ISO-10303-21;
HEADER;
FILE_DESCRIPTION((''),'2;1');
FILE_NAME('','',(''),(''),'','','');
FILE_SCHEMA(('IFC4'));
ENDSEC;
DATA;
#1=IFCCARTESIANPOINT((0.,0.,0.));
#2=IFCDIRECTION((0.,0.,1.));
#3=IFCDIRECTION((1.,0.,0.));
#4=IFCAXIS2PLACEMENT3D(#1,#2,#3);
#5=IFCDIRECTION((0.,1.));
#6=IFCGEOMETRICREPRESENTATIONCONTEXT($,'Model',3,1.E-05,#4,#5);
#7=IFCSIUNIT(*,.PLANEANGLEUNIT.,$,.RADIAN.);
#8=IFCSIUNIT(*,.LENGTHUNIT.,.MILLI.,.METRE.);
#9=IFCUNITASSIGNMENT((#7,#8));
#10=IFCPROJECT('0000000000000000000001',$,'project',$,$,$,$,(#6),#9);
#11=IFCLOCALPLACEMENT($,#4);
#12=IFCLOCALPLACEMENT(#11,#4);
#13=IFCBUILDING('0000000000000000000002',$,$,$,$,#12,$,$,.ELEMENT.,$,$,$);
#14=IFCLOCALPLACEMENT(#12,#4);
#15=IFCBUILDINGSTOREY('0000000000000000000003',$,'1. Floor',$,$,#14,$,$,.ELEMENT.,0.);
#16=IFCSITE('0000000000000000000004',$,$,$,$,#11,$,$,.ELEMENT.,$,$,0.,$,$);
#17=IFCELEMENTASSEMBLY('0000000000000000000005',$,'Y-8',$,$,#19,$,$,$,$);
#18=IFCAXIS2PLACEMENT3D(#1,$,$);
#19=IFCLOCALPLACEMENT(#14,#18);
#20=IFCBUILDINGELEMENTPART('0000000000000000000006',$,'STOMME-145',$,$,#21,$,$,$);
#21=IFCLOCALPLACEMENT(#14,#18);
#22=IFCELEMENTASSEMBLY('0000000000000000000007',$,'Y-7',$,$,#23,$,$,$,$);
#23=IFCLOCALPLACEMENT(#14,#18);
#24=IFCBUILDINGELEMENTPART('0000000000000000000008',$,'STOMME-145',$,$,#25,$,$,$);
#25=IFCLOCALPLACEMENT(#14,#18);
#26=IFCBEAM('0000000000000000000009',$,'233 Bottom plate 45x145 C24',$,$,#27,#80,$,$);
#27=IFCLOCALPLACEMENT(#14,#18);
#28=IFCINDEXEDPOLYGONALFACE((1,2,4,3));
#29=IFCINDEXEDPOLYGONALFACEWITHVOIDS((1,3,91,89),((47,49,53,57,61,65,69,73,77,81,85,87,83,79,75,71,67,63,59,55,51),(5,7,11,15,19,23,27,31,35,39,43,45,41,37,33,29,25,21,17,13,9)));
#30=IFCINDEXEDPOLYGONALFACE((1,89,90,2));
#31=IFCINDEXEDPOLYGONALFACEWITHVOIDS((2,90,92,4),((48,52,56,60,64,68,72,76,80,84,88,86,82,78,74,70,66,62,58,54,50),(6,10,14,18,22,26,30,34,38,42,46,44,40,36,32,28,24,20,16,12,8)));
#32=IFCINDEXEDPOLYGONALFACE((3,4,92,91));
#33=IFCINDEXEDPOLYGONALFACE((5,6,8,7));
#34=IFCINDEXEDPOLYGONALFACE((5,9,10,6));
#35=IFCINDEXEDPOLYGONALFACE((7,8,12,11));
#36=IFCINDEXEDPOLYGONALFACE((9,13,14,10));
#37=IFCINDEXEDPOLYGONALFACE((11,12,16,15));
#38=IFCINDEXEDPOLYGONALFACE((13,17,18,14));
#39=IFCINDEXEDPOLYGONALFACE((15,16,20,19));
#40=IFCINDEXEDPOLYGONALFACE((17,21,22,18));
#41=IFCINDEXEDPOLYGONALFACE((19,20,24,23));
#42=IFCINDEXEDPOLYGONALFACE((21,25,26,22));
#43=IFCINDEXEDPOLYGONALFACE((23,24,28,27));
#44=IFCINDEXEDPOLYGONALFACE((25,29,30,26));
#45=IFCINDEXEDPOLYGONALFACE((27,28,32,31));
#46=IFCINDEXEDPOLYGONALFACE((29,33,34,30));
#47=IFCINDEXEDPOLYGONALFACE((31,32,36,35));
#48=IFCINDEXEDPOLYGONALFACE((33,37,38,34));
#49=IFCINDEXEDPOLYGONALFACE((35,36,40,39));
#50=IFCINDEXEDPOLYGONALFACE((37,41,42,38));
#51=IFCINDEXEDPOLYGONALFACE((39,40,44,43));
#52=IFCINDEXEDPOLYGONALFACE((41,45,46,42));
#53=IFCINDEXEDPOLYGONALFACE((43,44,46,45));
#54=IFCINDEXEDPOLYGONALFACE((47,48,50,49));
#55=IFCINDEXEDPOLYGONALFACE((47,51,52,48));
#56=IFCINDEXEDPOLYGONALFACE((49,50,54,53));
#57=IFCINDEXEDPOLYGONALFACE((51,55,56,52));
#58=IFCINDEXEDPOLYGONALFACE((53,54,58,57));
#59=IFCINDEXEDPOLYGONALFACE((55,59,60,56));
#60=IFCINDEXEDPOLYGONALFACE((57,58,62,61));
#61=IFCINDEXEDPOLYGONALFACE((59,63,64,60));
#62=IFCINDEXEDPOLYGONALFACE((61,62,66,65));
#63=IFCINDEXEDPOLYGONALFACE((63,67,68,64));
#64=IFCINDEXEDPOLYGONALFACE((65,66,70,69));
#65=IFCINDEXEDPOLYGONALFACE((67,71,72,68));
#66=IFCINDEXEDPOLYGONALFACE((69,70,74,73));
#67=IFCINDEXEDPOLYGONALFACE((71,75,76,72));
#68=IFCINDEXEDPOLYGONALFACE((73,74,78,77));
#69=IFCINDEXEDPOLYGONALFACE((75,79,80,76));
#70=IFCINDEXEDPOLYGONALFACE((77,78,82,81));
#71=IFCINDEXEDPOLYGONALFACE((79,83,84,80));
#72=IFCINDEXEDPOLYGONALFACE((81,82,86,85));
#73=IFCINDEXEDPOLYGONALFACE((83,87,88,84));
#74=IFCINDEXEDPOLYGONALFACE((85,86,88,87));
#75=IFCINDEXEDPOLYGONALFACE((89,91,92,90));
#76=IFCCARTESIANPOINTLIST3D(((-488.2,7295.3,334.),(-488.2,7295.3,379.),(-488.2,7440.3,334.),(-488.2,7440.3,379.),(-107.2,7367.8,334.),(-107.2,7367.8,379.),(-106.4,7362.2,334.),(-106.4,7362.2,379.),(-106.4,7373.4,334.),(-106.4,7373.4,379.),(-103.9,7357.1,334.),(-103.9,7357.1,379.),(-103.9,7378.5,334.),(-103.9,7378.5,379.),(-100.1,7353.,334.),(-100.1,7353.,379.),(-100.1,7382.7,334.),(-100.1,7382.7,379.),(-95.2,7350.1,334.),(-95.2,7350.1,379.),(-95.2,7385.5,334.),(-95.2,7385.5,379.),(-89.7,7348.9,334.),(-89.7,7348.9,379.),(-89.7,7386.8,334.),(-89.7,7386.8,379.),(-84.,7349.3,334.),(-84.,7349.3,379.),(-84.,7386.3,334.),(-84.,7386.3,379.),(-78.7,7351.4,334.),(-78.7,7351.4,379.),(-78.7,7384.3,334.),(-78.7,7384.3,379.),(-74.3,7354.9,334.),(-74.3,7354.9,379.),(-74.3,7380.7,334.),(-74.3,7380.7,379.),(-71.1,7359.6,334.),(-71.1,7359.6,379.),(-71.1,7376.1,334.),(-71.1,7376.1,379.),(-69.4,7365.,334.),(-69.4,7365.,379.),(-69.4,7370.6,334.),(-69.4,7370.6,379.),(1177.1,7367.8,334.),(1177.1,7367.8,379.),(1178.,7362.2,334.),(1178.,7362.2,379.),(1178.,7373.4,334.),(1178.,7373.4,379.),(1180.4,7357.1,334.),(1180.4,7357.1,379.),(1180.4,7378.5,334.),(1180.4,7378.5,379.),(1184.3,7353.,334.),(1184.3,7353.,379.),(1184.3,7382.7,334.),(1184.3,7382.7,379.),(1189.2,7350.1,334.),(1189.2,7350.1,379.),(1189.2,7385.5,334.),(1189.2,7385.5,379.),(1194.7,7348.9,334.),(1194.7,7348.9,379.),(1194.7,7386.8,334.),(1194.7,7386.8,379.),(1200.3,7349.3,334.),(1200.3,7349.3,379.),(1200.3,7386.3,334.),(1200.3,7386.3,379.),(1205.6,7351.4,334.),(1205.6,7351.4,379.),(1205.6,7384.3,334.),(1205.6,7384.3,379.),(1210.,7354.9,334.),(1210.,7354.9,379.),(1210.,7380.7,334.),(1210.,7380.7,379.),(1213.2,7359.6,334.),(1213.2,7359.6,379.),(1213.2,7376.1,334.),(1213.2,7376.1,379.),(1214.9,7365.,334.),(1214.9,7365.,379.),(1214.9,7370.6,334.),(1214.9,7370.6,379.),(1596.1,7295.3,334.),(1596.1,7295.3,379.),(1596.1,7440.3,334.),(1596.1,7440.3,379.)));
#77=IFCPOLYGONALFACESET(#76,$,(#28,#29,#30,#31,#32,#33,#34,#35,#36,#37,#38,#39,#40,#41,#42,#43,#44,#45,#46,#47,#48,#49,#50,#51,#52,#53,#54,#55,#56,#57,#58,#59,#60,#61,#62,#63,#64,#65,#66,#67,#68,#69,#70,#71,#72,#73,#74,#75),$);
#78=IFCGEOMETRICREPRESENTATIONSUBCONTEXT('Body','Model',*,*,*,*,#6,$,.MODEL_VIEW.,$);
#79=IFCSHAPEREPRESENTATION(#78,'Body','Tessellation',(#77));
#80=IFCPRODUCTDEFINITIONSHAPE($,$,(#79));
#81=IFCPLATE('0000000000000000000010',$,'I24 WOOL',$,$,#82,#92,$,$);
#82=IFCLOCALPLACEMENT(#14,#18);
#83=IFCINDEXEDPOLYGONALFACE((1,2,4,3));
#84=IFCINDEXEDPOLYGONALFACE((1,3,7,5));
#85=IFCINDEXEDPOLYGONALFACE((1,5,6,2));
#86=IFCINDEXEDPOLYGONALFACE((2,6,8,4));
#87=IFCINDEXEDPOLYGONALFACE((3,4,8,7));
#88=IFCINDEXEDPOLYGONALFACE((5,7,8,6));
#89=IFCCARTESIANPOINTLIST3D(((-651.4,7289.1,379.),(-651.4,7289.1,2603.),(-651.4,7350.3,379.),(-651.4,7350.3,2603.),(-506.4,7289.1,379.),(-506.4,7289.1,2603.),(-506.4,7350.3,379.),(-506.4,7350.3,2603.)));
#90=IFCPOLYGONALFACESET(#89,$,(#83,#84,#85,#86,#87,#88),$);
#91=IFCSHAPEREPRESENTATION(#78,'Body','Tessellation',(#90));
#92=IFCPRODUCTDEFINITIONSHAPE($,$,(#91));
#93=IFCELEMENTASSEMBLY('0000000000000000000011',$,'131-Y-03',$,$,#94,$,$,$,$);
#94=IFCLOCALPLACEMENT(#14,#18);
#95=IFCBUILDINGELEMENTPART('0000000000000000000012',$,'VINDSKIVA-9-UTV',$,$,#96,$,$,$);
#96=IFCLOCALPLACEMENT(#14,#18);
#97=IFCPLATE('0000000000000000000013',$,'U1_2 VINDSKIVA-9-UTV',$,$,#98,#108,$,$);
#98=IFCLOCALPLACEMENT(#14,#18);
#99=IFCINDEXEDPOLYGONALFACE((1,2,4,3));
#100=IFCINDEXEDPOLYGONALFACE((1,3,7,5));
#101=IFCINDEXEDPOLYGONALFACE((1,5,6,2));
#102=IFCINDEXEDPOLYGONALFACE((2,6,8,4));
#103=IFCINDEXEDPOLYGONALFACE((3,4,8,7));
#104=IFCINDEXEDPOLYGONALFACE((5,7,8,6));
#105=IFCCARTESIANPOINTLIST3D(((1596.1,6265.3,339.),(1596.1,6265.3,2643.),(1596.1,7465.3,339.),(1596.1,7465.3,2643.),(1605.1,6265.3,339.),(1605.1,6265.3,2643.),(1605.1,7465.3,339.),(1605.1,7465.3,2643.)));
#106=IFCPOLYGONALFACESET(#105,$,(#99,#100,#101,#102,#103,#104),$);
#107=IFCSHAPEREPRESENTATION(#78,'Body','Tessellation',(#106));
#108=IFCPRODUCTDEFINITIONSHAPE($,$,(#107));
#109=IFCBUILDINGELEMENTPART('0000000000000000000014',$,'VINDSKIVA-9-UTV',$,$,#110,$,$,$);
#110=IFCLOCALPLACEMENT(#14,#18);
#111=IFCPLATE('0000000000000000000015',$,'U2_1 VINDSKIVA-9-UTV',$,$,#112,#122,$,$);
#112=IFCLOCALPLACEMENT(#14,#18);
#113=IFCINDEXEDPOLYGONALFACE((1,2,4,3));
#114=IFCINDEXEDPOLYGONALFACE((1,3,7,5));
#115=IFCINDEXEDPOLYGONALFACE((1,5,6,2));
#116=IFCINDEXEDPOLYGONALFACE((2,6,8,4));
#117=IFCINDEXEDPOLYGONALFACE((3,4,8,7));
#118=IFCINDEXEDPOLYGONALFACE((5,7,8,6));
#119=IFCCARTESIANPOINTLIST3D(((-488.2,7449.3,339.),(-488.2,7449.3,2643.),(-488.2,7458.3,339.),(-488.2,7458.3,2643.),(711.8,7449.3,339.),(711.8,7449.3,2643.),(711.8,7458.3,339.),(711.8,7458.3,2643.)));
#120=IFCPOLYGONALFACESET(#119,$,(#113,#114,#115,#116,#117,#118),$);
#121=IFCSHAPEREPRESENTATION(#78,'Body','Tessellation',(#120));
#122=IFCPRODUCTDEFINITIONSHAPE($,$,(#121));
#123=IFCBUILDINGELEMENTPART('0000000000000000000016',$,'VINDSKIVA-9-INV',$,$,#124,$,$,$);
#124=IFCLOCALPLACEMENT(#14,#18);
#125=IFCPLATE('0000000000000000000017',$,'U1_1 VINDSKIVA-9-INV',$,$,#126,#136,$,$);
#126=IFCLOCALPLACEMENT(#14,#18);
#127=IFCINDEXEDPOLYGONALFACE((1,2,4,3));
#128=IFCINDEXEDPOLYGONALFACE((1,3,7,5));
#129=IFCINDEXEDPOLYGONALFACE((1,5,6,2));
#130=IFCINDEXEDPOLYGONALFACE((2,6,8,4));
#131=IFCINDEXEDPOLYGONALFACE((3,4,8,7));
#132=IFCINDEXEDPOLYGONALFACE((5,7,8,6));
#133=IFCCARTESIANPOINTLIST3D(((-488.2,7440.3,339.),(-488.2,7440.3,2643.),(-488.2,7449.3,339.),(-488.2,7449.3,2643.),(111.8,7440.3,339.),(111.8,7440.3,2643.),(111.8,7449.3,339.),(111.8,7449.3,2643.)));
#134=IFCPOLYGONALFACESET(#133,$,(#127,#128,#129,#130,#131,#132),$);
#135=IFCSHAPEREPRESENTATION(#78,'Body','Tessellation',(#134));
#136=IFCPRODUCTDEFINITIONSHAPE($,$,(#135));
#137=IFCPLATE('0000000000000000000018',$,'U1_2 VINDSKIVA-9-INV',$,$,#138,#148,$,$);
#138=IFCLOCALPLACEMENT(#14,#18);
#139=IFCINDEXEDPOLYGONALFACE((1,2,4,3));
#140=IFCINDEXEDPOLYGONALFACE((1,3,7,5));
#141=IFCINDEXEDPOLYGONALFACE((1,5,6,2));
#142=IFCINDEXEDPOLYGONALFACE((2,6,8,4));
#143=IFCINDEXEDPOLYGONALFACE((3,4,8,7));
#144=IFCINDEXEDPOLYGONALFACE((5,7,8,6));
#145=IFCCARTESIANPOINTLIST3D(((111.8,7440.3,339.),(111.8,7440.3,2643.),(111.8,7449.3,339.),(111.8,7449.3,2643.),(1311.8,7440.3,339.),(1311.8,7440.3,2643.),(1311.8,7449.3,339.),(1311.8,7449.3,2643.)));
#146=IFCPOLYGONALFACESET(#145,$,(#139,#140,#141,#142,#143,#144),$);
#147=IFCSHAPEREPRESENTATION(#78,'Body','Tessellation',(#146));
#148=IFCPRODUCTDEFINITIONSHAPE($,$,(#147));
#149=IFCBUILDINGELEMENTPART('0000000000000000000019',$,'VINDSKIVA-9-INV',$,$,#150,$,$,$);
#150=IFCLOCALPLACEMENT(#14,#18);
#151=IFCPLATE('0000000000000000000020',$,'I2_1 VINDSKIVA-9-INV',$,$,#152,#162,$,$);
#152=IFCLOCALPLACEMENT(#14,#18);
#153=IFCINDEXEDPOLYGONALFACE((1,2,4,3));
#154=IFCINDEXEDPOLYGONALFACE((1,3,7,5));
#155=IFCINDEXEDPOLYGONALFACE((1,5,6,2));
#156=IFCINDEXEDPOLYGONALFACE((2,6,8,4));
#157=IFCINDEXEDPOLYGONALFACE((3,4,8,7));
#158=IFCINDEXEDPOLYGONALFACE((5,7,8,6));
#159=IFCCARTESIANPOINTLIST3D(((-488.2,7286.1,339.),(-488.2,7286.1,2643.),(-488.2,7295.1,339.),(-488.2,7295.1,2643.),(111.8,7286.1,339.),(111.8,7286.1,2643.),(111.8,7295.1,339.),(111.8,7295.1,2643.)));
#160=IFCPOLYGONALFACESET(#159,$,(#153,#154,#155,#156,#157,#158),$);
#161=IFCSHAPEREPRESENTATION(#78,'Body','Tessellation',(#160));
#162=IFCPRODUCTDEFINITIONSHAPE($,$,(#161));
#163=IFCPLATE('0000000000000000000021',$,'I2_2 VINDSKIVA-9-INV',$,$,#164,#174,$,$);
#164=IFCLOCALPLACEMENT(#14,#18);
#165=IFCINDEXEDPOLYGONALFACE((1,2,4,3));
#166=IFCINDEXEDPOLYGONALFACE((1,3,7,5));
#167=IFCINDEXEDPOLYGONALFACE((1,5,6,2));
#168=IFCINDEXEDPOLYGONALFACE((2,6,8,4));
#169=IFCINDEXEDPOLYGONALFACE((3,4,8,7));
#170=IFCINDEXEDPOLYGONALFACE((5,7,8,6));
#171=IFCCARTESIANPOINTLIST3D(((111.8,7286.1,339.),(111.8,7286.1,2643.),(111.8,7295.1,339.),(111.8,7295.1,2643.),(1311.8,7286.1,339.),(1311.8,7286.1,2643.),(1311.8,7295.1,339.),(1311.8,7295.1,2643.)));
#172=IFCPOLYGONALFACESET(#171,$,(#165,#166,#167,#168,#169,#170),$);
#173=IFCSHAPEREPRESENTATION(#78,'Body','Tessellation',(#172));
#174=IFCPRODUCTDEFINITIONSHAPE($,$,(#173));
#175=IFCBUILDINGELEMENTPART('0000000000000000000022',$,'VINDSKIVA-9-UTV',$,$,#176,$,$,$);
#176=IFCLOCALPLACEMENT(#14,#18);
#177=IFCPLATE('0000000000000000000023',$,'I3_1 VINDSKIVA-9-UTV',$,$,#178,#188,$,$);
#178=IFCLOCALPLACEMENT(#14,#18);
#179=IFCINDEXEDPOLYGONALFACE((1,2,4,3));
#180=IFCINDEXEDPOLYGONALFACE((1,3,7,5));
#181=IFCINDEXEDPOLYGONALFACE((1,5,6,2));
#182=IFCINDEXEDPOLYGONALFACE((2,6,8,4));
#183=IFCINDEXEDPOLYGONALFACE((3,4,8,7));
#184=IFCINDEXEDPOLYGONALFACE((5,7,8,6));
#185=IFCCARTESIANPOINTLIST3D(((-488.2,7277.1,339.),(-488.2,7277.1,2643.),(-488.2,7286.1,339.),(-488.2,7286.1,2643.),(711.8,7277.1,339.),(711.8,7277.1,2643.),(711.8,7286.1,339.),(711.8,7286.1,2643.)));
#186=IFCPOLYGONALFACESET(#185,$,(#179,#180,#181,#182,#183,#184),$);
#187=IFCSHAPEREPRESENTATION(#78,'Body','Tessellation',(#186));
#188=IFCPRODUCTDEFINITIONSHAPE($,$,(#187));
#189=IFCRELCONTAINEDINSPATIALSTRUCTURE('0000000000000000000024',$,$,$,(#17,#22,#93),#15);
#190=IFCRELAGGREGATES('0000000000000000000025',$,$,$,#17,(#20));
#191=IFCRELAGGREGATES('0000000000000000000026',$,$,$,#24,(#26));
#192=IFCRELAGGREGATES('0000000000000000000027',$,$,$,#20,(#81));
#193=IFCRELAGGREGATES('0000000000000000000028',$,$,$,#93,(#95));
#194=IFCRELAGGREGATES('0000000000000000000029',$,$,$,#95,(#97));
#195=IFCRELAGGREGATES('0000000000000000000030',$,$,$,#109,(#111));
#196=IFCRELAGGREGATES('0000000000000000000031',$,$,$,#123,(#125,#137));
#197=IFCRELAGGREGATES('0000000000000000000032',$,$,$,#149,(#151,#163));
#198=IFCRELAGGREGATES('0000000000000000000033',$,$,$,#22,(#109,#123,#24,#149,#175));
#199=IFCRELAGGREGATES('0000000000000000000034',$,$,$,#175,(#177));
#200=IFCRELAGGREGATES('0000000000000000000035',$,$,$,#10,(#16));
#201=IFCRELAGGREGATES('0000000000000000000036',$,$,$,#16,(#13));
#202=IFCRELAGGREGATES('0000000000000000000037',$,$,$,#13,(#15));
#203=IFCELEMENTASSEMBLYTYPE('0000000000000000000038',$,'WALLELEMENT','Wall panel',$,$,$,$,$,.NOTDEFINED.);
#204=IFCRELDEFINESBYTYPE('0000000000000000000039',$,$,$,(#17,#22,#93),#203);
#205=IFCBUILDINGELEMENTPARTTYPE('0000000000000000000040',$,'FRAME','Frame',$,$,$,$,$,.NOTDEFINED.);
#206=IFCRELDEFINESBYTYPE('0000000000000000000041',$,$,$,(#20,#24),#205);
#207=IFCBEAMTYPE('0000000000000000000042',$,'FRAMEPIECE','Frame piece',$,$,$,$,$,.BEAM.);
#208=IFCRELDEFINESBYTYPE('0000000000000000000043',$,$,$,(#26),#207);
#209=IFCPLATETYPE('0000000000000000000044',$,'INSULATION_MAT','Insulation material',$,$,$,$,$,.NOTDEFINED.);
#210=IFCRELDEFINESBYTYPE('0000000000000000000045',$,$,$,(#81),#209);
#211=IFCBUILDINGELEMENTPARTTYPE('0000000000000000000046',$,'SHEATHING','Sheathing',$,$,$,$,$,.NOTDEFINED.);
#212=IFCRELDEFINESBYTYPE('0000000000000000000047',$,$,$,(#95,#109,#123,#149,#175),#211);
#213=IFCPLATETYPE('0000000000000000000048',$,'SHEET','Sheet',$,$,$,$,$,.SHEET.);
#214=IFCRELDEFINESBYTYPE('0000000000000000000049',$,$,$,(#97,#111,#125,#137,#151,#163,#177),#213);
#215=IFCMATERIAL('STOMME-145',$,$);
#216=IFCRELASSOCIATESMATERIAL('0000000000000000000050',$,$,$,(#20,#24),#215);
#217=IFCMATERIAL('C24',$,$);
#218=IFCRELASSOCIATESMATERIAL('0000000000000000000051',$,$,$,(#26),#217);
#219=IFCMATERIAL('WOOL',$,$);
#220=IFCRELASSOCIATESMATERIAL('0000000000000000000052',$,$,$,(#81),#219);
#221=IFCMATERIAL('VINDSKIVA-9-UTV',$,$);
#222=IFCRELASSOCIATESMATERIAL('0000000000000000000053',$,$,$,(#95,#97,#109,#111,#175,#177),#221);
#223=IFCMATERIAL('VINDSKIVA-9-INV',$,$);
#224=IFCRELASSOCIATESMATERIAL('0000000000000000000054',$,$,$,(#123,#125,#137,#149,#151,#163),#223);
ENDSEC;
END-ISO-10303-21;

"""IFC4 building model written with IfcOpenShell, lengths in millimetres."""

from ifc_helpers import new_model, si_unit, direction, frame, origin_with_axes, origin_2d_with_axis, place, context, subcontext, project, spatial, rectangle, circle, extrude, boolean, material, type_object, element, aggregate, save


model = new_model("IFC4")

# Units and contexts
model_context = context("Model", 3, precision=1e-05, world=origin_with_axes(), true_north=direction((0.0, 1.0)))
body_context = subcontext(model_context, "Body", "Model", "MODEL_VIEW")
ifc_project = project(units=[si_unit("PLANEANGLEUNIT", "RADIAN"), si_unit("LENGTHUNIT", "METRE", prefix="MILLI")], contexts=[model_context])

# Site, building, storey
site_placement = place(None, origin_with_axes())
site = spatial("IfcSite", under=ifc_project, at=site_placement, CompositionType="ELEMENT", RefElevation=0.0)
building_placement = place(site_placement, origin_with_axes())
building = spatial("IfcBuilding", under=site, at=building_placement, CompositionType="ELEMENT")
storey_placement = place(building_placement, origin_with_axes())
storey = spatial("IfcBuildingStorey", under=building, at=storey_placement, Name="1. Floor", CompositionType="ELEMENT", Elevation=0.0)

# Element assemblies, building element parts
element_assembly_type = type_object("IfcElementAssemblyType", Name="WALLELEMENT", Description="Wall panel", PredefinedType="NOTDEFINED")
assembly_1_placement = place(storey_placement, origin_with_axes())
assembly_1 = element("IfcElementAssembly", 1, at=assembly_1_placement, inside=storey, type_object=element_assembly_type, Name="Y-8")
ifc_material_1 = material(Name="STOMME-145")
building_element_part_type_1 = type_object("IfcBuildingElementPartType", Name="FRAME", Description="Frame", PredefinedType="NOTDEFINED")
building_element_part_1_placement = place(storey_placement, origin_with_axes())
building_element_part_1 = element("IfcBuildingElementPart", 2, at=building_element_part_1_placement, type_object=building_element_part_type_1, material=ifc_material_1, Name="STOMME-145")
ifc_material_2 = material(Name="C24")
assembly_2_placement = place(storey_placement, origin_with_axes())
assembly_2 = element("IfcElementAssembly", 3, at=assembly_2_placement, inside=storey, type_object=element_assembly_type, Name="Y-7")
building_element_part_2_placement = place(storey_placement, origin_with_axes())
building_element_part_2 = element("IfcBuildingElementPart", 4, at=building_element_part_2_placement, type_object=building_element_part_type_1, material=ifc_material_1, Name="STOMME-145")

aggregate(assembly_1, [building_element_part_1])

# Shared definitions
beam_type = type_object("IfcBeamType", Name="FRAMEPIECE", Description="Frame piece", PredefinedType="BEAM")

# Beam
beam_1_placement = place(storey_placement, frame((1596.1, 7367.8, 356.5), z_axis=(-1.0, 0.0, 0.0), x_axis=(0.0, 0.0, 1.0)))
beam_1 = element("IfcBeam", 5, at=beam_1_placement, type_object=beam_type, material=ifc_material_2, Name="233 Bottom plate 45x145 C24", context=body_context, shape_type="CSG", body=[
    boolean("DIFFERENCE", boolean("DIFFERENCE", extrude(rectangle(XDim=45.0, YDim=145.0, at=origin_2d_with_axis()), origin_with_axes(), (0.0, 0.0, 1.0), 2084.3), extrude(circle(Radius=19.0, at=origin_2d_with_axis()), frame((-45.0, 0.0, 400.0), z_axis=(-1.0, 0.0, 0.0), x_axis=(0.0, 0.0, 1.0)), (0.0, 0.0, -1.0), 90.0)), extrude(circle(Radius=19.0, at=origin_2d_with_axis()), frame((-45.0, 0.0, 1684.4), z_axis=(-1.0, 0.0, 0.0), x_axis=(0.0, 0.0, 1.0)), (0.0, 0.0, -1.0), 90.0)),
])
aggregate(building_element_part_2, [beam_1])

# Plate
ifc_material_3 = material(Name="WOOL")
plate_type_1 = type_object("IfcPlateType", Name="INSULATION_MAT", Description="Insulation material", PredefinedType="NOTDEFINED")
plate_1_placement = place(storey_placement, frame((-651.4, 7319.7, 1491.0), z_axis=(-1.0, 0.0, 0.0), x_axis=(0.0, -1.0, 0.0)))
plate_1 = element("IfcPlate", 6, at=plate_1_placement, type_object=plate_type_1, material=ifc_material_3, Name="I24 WOOL", context=body_context, shape_type="SweptSolid", body=[
    extrude(rectangle(XDim=145.0, YDim=61.2, at=origin_2d_with_axis()), frame((0.0, -1112.0, -72.5), z_axis=(0.0, 1.0, 0.0), x_axis=(0.0, 0.0, 1.0)), (0.0, 0.0, 1.0), 2224.0),
])
aggregate(building_element_part_1, [plate_1])

# Element assembly, building element part, plate
assembly_3_placement = place(storey_placement, origin_with_axes())
assembly_3 = element("IfcElementAssembly", 7, at=assembly_3_placement, inside=storey, type_object=element_assembly_type, Name="131-Y-03")
ifc_material_4 = material(Name="VINDSKIVA-9-UTV")
building_element_part_type_2 = type_object("IfcBuildingElementPartType", Name="SHEATHING", Description="Sheathing", PredefinedType="NOTDEFINED")
building_element_part_3_placement = place(storey_placement, origin_with_axes())
building_element_part_3 = element("IfcBuildingElementPart", 8, at=building_element_part_3_placement, type_object=building_element_part_type_2, material=ifc_material_4, Name="VINDSKIVA-9-UTV")
aggregate(assembly_3, [building_element_part_3])
plate_type_2 = type_object("IfcPlateType", Name="SHEET", Description="Sheet", PredefinedType="SHEET")
plate_2_placement = place(storey_placement, frame((1596.1, 6865.3, 2339.0), z_axis=(-1.0, 0.0, 0.0), x_axis=(0.0, 1.0, 0.0)))
plate_2 = element("IfcPlate", 9, at=plate_2_placement, type_object=plate_type_2, material=ifc_material_4, Name="U1_2 VINDSKIVA-9-UTV", context=body_context, shape_type="SweptSolid", body=[
    extrude(rectangle(XDim=9.0, YDim=1200.0, at=origin_2d_with_axis()), frame((0.0, -304.0, -4.5), z_axis=(0.0, 1.0, 0.0), x_axis=(0.0, 0.0, 1.0)), (0.0, 0.0, 1.0), 2304.0),
])
aggregate(building_element_part_3, [plate_2])

# Building element parts, plates
building_element_part_4_placement = place(storey_placement, origin_with_axes())
building_element_part_4 = element("IfcBuildingElementPart", 10, at=building_element_part_4_placement, type_object=building_element_part_type_2, material=ifc_material_4, Name="VINDSKIVA-9-UTV")
plate_3_placement = place(storey_placement, frame((111.8, 7458.3, 2339.0), z_axis=(0.0, 1.0, 0.0), x_axis=(-1.0, 0.0, 0.0)))
plate_3 = element("IfcPlate", 11, at=plate_3_placement, type_object=plate_type_2, material=ifc_material_4, Name="U2_1 VINDSKIVA-9-UTV", context=body_context, shape_type="SweptSolid", body=[
    extrude(rectangle(XDim=9.0, YDim=1200.0, at=origin_2d_with_axis()), frame((0.0, -2000.0, -4.5), z_axis=(0.0, 1.0, 0.0), x_axis=(0.0, 0.0, 1.0)), (0.0, 0.0, 1.0), 2304.0),
])
aggregate(building_element_part_4, [plate_3])
ifc_material_5 = material(Name="VINDSKIVA-9-INV")
building_element_part_5_placement = place(storey_placement, origin_with_axes())
building_element_part_5 = element("IfcBuildingElementPart", 12, at=building_element_part_5_placement, type_object=building_element_part_type_2, material=ifc_material_5, Name="VINDSKIVA-9-INV")
plate_4_placement = place(storey_placement, frame((-488.2, 7449.3, 2339.0), z_axis=(0.0, 1.0, 0.0), x_axis=(-1.0, 0.0, 0.0)))
plate_4 = element("IfcPlate", 13, at=plate_4_placement, type_object=plate_type_2, material=ifc_material_5, Name="U1_1 VINDSKIVA-9-INV", context=body_context, shape_type="SweptSolid", body=[
    extrude(rectangle(XDim=9.0, YDim=600.0, at=origin_2d_with_axis()), frame((-300.0, -2000.0, -4.5), z_axis=(0.0, 1.0, 0.0), x_axis=(0.0, 0.0, 1.0)), (0.0, 0.0, 1.0), 2304.0),
])
plate_5_placement = place(storey_placement, frame((711.8, 7449.3, 2339.0), z_axis=(0.0, 1.0, 0.0), x_axis=(-1.0, 0.0, 0.0)))
plate_5 = element("IfcPlate", 14, at=plate_5_placement, type_object=plate_type_2, material=ifc_material_5, Name="U1_2 VINDSKIVA-9-INV", context=body_context, shape_type="SweptSolid", body=[
    extrude(rectangle(XDim=9.0, YDim=1200.0, at=origin_2d_with_axis()), frame((0.0, -2000.0, -4.5), z_axis=(0.0, 1.0, 0.0), x_axis=(0.0, 0.0, 1.0)), (0.0, 0.0, 1.0), 2304.0),
])
aggregate(building_element_part_5, [plate_4, plate_5])
building_element_part_6_placement = place(storey_placement, origin_with_axes())
building_element_part_6 = element("IfcBuildingElementPart", 15, at=building_element_part_6_placement, type_object=building_element_part_type_2, material=ifc_material_5, Name="VINDSKIVA-9-INV")
plate_6_placement = place(storey_placement, frame((-488.2, 7295.1, 2339.0), z_axis=(0.0, 1.0, 0.0), x_axis=(-1.0, 0.0, 0.0)))
plate_6 = element("IfcPlate", 16, at=plate_6_placement, type_object=plate_type_2, material=ifc_material_5, Name="I2_1 VINDSKIVA-9-INV", context=body_context, shape_type="SweptSolid", body=[
    extrude(rectangle(XDim=9.0, YDim=600.0, at=origin_2d_with_axis()), frame((-300.0, -2000.0, -4.5), z_axis=(0.0, 1.0, 0.0), x_axis=(0.0, 0.0, 1.0)), (0.0, 0.0, 1.0), 2304.0),
])
plate_7_placement = place(storey_placement, frame((711.8, 7295.1, 2339.0), z_axis=(0.0, 1.0, 0.0), x_axis=(-1.0, 0.0, 0.0)))
plate_7 = element("IfcPlate", 17, at=plate_7_placement, type_object=plate_type_2, material=ifc_material_5, Name="I2_2 VINDSKIVA-9-INV", context=body_context, shape_type="SweptSolid", body=[
    extrude(rectangle(XDim=9.0, YDim=1200.0, at=origin_2d_with_axis()), frame((0.0, -2000.0, -4.5), z_axis=(0.0, 1.0, 0.0), x_axis=(0.0, 0.0, 1.0)), (0.0, 0.0, 1.0), 2304.0),
])
aggregate(building_element_part_6, [plate_6, plate_7])

# Building element part
building_element_part_7_placement = place(storey_placement, origin_with_axes())
building_element_part_7 = element("IfcBuildingElementPart", 18, at=building_element_part_7_placement, type_object=building_element_part_type_2, material=ifc_material_4, Name="VINDSKIVA-9-UTV")
aggregate(assembly_2, [building_element_part_4, building_element_part_5, building_element_part_2, building_element_part_6, building_element_part_7])

# Plate
plate_8_placement = place(storey_placement, frame((111.8, 7286.1, 2339.0), z_axis=(0.0, 1.0, 0.0), x_axis=(-1.0, 0.0, 0.0)))
plate_8 = element("IfcPlate", 19, at=plate_8_placement, type_object=plate_type_2, material=ifc_material_4, Name="I3_1 VINDSKIVA-9-UTV", context=body_context, shape_type="SweptSolid", body=[
    extrude(rectangle(XDim=9.0, YDim=1200.0, at=origin_2d_with_axis()), frame((0.0, -2000.0, -4.5), z_axis=(0.0, 1.0, 0.0), x_axis=(0.0, 0.0, 1.0)), (0.0, 0.0, 1.0), 2304.0),
])
aggregate(building_element_part_7, [plate_8])

save(model, "model.ifc")
